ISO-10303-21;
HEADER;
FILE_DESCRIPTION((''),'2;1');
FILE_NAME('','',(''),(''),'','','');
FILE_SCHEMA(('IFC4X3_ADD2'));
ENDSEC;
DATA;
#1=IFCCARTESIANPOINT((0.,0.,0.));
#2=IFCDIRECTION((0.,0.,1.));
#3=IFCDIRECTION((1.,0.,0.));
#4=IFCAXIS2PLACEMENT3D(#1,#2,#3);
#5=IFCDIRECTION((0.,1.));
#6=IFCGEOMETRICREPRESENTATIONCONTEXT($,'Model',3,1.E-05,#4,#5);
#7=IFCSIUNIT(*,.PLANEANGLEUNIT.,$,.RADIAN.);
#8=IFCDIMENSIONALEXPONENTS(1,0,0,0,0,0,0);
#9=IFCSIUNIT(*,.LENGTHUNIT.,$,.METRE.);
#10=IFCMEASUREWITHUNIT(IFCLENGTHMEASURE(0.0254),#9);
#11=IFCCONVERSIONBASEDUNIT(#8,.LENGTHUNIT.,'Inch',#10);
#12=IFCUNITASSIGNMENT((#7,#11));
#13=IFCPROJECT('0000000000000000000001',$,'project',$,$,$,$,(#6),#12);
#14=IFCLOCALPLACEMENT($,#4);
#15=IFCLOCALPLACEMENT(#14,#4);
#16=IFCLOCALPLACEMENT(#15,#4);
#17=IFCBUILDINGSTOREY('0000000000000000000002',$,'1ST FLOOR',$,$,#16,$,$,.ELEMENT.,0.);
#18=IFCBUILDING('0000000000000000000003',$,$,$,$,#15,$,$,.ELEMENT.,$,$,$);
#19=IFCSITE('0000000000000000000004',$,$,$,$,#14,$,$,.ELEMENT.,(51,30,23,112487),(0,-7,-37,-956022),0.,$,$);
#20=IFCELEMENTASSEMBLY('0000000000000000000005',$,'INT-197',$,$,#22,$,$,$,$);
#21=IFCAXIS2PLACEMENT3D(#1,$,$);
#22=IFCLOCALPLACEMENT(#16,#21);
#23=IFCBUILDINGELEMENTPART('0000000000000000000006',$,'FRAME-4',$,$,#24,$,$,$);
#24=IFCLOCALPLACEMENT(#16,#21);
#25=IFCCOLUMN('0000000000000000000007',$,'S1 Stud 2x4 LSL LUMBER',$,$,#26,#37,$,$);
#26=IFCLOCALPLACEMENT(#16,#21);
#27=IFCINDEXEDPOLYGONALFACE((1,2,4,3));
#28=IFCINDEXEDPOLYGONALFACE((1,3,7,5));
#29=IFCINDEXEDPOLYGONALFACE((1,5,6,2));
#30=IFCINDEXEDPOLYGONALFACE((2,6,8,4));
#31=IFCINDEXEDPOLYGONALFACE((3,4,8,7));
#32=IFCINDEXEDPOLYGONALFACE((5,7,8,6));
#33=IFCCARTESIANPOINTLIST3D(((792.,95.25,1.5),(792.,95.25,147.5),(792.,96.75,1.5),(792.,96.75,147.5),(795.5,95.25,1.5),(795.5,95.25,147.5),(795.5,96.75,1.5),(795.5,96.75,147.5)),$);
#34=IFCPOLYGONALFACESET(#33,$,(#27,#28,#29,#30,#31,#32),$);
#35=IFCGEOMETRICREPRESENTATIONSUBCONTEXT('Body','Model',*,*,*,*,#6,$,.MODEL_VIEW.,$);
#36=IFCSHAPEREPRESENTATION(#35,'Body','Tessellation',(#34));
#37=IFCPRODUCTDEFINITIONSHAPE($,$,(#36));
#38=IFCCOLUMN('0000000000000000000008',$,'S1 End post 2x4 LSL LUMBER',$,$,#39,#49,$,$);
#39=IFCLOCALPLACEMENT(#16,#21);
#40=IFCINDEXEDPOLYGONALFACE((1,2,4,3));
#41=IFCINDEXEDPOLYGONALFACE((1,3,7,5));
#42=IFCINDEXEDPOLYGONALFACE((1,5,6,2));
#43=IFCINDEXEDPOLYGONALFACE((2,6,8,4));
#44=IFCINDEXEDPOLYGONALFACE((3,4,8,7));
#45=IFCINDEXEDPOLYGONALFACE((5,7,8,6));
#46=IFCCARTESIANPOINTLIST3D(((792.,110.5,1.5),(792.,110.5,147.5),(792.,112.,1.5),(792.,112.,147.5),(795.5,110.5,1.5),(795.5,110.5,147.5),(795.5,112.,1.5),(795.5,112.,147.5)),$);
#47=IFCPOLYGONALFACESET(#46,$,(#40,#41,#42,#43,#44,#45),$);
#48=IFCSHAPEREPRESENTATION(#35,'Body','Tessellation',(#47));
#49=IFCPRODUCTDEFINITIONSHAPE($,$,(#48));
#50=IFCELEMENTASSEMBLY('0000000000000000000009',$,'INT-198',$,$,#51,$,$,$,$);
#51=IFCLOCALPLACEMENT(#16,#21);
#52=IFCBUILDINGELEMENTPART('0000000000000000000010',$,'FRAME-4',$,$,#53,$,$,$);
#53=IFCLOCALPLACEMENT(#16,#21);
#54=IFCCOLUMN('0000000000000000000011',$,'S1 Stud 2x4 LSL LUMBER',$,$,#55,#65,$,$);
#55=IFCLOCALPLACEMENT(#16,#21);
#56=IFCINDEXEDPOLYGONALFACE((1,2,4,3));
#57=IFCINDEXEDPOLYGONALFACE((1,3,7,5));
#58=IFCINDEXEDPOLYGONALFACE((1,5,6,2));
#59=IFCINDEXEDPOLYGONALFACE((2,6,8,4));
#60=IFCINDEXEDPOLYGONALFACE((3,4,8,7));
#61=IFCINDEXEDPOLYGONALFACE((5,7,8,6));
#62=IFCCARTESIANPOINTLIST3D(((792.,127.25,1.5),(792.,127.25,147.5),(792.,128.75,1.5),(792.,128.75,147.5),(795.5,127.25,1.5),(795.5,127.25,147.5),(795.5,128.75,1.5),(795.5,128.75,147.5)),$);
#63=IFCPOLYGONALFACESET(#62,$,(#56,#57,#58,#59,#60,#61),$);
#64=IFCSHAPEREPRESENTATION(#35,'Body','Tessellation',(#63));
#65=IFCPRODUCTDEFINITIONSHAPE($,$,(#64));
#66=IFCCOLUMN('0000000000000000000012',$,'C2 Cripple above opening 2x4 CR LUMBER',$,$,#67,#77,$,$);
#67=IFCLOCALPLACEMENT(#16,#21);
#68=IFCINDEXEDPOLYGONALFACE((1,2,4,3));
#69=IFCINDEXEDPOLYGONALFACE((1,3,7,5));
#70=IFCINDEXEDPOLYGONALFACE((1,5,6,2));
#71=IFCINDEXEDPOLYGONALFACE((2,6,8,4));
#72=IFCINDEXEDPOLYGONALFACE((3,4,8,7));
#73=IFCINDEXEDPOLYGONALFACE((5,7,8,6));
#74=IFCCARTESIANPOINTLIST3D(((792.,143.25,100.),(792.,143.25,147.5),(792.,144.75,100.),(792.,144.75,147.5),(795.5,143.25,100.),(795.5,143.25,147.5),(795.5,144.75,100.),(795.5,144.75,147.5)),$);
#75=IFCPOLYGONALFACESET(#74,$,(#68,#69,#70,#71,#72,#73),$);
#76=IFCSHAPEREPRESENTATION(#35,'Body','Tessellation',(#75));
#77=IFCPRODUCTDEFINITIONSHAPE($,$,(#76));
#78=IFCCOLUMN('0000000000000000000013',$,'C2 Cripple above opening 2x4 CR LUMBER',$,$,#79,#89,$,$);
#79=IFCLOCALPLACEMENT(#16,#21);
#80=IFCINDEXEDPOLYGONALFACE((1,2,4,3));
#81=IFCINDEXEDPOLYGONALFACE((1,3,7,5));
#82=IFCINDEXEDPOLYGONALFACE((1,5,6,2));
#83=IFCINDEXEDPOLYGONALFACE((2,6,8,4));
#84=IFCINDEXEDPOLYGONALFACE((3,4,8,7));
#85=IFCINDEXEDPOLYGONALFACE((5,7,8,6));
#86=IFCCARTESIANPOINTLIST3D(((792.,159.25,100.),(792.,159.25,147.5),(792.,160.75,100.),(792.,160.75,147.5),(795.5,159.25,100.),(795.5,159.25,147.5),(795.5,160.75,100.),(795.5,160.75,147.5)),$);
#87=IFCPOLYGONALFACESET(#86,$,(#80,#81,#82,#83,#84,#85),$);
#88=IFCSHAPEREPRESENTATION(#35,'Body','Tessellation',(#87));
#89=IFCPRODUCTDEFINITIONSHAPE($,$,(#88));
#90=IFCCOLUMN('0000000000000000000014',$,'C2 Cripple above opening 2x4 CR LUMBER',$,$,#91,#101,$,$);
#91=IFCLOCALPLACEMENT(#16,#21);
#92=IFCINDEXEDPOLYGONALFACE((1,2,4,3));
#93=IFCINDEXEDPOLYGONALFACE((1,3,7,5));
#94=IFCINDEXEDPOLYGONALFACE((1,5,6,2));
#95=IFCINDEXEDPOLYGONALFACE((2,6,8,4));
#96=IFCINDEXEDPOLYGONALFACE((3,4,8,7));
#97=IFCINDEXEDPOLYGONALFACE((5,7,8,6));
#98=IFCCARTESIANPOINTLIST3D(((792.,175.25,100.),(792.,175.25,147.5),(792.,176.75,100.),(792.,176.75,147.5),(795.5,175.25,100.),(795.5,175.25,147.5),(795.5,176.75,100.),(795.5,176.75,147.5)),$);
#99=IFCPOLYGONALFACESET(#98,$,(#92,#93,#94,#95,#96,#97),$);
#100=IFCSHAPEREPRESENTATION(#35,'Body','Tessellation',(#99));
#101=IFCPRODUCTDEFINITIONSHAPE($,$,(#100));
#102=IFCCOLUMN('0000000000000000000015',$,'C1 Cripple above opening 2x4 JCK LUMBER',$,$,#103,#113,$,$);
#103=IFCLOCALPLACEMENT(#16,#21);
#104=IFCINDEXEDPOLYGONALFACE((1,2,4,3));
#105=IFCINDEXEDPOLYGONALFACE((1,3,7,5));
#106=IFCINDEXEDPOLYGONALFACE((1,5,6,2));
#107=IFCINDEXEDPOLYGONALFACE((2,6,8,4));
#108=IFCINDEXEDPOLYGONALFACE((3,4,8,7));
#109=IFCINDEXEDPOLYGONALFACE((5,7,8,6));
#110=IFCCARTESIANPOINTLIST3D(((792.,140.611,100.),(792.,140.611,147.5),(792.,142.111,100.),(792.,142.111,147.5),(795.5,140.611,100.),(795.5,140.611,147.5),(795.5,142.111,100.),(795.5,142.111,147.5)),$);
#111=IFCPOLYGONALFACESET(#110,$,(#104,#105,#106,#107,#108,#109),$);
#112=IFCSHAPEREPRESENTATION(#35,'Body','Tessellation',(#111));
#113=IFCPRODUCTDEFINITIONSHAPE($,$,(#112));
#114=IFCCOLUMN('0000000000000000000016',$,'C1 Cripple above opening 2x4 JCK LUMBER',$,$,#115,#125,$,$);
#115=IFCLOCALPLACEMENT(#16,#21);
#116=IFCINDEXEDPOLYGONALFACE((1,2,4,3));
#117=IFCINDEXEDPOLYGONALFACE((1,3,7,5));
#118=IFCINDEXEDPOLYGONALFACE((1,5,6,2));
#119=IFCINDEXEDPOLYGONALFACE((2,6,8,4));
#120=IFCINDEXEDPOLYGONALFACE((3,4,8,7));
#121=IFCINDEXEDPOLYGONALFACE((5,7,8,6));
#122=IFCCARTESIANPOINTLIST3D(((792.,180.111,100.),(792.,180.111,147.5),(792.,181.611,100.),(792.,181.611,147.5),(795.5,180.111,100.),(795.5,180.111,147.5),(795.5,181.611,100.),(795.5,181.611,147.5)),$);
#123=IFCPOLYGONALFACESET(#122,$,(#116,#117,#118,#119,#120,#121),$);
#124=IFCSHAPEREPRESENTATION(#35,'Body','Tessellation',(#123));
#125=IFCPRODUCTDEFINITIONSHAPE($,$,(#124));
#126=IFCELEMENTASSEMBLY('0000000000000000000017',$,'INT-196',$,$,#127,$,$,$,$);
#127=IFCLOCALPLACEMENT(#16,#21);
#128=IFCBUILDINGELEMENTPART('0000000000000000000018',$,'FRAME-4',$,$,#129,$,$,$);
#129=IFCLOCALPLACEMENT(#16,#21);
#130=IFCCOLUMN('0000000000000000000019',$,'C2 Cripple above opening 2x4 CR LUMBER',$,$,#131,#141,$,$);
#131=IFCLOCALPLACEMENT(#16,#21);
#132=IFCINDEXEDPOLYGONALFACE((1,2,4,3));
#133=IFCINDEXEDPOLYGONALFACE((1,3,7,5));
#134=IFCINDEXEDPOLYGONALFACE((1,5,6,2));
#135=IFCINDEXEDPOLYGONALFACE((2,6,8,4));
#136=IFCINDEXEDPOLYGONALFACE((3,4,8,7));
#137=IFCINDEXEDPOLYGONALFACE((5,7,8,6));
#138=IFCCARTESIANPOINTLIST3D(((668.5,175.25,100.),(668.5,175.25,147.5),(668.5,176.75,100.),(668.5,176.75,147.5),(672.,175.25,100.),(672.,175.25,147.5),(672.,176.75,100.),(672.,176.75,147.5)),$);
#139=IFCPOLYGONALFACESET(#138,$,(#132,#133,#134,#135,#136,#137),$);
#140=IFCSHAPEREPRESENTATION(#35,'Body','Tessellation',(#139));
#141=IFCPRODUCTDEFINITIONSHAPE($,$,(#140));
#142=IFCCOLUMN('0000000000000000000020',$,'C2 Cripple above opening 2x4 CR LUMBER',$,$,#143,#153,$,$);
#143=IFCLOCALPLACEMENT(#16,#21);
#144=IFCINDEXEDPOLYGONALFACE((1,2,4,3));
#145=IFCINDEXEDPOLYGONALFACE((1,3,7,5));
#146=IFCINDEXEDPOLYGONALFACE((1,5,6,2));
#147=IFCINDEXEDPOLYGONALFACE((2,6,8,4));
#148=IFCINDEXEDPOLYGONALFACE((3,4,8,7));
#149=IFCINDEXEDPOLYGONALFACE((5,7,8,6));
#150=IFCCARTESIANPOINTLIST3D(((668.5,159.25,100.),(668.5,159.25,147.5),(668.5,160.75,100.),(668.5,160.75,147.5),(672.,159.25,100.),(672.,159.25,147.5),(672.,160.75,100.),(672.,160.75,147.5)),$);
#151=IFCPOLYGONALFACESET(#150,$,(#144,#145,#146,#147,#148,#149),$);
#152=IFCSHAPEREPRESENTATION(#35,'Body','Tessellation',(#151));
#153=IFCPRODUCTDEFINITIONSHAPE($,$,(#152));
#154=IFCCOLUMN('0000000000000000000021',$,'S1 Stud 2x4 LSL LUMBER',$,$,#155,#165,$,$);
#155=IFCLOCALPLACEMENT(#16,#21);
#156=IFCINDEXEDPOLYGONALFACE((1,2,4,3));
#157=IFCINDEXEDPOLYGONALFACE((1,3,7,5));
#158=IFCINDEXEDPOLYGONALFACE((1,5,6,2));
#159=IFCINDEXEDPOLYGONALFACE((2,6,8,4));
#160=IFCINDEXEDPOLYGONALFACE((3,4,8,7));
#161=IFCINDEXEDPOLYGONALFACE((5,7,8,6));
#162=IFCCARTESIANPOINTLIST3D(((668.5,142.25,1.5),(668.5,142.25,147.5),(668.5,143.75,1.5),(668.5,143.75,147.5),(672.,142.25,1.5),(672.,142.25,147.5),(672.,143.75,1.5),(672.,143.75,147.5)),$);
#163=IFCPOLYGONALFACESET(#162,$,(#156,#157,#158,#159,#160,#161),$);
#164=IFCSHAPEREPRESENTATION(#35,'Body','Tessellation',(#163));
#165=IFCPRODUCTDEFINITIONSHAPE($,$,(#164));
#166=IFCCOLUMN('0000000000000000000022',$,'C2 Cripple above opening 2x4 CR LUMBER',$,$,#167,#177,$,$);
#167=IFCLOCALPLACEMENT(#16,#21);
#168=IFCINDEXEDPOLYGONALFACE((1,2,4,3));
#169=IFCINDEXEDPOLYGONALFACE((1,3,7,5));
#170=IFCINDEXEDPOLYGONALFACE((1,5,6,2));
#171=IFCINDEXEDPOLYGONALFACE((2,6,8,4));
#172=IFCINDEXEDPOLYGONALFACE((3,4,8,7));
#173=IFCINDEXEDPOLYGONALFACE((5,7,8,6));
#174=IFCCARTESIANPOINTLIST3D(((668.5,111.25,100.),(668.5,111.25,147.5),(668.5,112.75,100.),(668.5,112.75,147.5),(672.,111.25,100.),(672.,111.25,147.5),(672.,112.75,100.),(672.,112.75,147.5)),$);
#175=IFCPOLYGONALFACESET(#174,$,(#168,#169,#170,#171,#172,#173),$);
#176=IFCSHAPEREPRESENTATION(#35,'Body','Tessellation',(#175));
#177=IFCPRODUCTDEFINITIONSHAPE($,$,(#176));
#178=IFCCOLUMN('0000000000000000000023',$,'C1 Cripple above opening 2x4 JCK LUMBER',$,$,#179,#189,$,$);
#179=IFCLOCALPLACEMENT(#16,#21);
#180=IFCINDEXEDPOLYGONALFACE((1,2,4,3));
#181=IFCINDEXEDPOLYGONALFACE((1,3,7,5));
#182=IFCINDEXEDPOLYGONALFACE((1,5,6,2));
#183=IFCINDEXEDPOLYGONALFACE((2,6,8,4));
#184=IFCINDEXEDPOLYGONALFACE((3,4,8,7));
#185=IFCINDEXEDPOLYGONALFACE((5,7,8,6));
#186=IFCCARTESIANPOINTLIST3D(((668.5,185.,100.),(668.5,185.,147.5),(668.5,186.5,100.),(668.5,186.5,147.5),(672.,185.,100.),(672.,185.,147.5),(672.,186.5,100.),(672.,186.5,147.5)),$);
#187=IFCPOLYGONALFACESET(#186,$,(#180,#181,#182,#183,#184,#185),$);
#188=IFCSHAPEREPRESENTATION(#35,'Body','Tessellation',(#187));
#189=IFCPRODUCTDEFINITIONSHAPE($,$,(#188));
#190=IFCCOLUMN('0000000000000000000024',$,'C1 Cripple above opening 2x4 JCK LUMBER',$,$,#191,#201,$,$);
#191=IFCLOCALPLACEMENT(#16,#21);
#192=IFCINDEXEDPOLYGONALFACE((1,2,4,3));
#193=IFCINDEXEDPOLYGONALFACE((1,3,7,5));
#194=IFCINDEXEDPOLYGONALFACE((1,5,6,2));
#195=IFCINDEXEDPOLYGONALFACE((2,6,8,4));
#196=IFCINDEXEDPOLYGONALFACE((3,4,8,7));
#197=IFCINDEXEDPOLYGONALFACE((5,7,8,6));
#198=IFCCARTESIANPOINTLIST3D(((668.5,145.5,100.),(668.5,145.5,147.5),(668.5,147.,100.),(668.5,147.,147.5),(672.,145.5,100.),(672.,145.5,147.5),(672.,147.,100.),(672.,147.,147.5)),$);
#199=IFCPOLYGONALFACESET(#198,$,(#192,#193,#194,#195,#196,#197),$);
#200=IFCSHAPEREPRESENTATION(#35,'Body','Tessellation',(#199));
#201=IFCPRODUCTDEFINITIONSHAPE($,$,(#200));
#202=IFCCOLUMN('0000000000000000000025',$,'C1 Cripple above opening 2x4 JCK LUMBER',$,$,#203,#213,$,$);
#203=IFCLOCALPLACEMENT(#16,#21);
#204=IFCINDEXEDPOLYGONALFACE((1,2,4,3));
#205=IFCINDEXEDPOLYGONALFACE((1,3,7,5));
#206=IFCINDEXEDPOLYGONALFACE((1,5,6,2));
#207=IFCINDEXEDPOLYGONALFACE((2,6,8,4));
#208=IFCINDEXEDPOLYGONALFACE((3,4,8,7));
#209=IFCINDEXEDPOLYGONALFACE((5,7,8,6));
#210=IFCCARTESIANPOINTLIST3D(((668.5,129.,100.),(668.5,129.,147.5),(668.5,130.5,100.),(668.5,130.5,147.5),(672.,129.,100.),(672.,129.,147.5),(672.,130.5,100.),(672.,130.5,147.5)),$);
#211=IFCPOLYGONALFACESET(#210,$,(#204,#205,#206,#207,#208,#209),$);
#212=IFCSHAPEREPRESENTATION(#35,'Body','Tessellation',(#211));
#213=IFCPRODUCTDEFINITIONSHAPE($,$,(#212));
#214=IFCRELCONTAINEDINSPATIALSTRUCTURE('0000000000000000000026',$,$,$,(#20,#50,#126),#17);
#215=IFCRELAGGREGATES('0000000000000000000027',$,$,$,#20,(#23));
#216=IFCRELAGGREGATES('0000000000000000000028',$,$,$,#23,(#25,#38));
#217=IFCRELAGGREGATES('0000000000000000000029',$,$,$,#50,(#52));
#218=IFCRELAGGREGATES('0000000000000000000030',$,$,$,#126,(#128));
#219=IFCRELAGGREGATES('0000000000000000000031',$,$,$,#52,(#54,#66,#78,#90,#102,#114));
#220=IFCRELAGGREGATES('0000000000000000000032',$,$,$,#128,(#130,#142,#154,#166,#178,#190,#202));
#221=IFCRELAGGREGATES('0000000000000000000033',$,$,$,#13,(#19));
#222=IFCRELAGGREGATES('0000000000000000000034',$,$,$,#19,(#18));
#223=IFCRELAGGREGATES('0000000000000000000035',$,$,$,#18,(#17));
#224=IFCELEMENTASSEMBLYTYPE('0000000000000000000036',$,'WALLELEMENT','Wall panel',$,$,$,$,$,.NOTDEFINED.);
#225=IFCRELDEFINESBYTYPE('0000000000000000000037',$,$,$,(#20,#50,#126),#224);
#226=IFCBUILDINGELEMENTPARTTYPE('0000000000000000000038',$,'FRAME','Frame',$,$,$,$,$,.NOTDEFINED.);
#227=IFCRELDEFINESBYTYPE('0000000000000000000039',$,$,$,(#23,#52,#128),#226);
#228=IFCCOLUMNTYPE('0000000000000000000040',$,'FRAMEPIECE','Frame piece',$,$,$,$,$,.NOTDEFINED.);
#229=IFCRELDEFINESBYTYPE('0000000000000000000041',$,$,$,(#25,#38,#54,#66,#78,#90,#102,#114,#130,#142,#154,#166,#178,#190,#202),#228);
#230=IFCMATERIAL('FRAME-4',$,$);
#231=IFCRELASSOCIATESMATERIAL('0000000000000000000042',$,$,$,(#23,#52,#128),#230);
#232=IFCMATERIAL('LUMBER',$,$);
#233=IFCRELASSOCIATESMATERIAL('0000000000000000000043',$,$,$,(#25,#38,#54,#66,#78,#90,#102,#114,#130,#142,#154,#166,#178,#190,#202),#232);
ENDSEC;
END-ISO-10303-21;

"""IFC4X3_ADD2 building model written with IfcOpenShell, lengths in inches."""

from ifc_helpers import new_model, entity, si_unit, converted_unit, direction, frame, origin_with_axes, origin_2d_with_axis, place, context, subcontext, project, spatial, rectangle, extrude, material, type_object, element, aggregate, save


model = new_model("IFC4X3_ADD2")

# Units and contexts
model_context = context("Model", 3, precision=1e-05, world=origin_with_axes(), true_north=direction((0.0, 1.0)))
body_context = subcontext(model_context, "Body", "Model", "MODEL_VIEW")
ifc_project = project(units=[si_unit("PLANEANGLEUNIT", "RADIAN"), converted_unit("LENGTHUNIT", "Inch", entity("IfcLengthMeasure", 0.0254), si_unit("LENGTHUNIT", "METRE"), dimensions=[1, 0, 0, 0, 0, 0, 0])], contexts=[model_context])

# Site, building, storey
site_placement = place(None, origin_with_axes())
site = spatial("IfcSite", under=ifc_project, at=site_placement, CompositionType="ELEMENT", RefLatitude=(51, 30, 23, 112487), RefLongitude=(0, -7, -37, -956022), RefElevation=0.0)
building_placement = place(site_placement, origin_with_axes())
building = spatial("IfcBuilding", under=site, at=building_placement, CompositionType="ELEMENT")
storey_placement = place(building_placement, origin_with_axes())
storey = spatial("IfcBuildingStorey", under=building, at=storey_placement, Name="1ST FLOOR", CompositionType="ELEMENT", Elevation=0.0)

# Element assemblies, building element parts, columns
element_assembly_type = type_object("IfcElementAssemblyType", Name="WALLELEMENT", Description="Wall panel", PredefinedType="NOTDEFINED")
assembly_1_placement = place(storey_placement, origin_with_axes())
assembly_1 = element("IfcElementAssembly", 1, at=assembly_1_placement, inside=storey, type_object=element_assembly_type, Name="INT-197")
ifc_material_1 = material(Name="FRAME-4")
building_element_part_type = type_object("IfcBuildingElementPartType", Name="FRAME", Description="Frame", PredefinedType="NOTDEFINED")
building_element_part_1_placement = place(storey_placement, origin_with_axes())
building_element_part_1 = element("IfcBuildingElementPart", 2, at=building_element_part_1_placement, type_object=building_element_part_type, material=ifc_material_1, Name="FRAME-4")
aggregate(assembly_1, [building_element_part_1])
ifc_material_2 = material(Name="LUMBER")
column_type = type_object("IfcColumnType", Name="FRAMEPIECE", Description="Frame piece", PredefinedType="NOTDEFINED")
column_1_placement = place(storey_placement, frame((793.75, 96.0, 147.5), z_axis=(0.0, 0.0, -1.0), x_axis=(0.0, -1.0, 0.0)))
column_1 = element("IfcColumn", 3, at=column_1_placement, type_object=column_type, material=ifc_material_2, Name="S1 Stud 2x4 LSL LUMBER", context=body_context, shape_type="SweptSolid", body=[
    extrude(rectangle(XDim=1.5, YDim=3.5, at=origin_2d_with_axis()), origin_with_axes(), (0.0, 0.0, 1.0), 146.0),
])
column_2_placement = place(storey_placement, frame((793.75, 111.25, 147.5), z_axis=(0.0, 0.0, -1.0), x_axis=(0.0, -1.0, 0.0)))
column_2 = element("IfcColumn", 4, at=column_2_placement, type_object=column_type, material=ifc_material_2, Name="S1 End post 2x4 LSL LUMBER", context=body_context, shape_type="SweptSolid", body=[
    extrude(rectangle(XDim=1.5, YDim=3.5, at=origin_2d_with_axis()), origin_with_axes(), (0.0, 0.0, 1.0), 146.0),
])
aggregate(building_element_part_1, [column_1, column_2])
assembly_2_placement = place(storey_placement, origin_with_axes())
assembly_2 = element("IfcElementAssembly", 5, at=assembly_2_placement, inside=storey, type_object=element_assembly_type, Name="INT-198")
building_element_part_2_placement = place(storey_placement, origin_with_axes())
building_element_part_2 = element("IfcBuildingElementPart", 6, at=building_element_part_2_placement, type_object=building_element_part_type, material=ifc_material_1, Name="FRAME-4")
aggregate(assembly_2, [building_element_part_2])
column_3_placement = place(storey_placement, frame((793.75, 128.0, 147.5), z_axis=(0.0, 0.0, -1.0), x_axis=(0.0, -1.0, 0.0)))
column_3 = element("IfcColumn", 7, at=column_3_placement, type_object=column_type, material=ifc_material_2, Name="S1 Stud 2x4 LSL LUMBER", context=body_context, shape_type="SweptSolid", body=[
    extrude(rectangle(XDim=1.5, YDim=3.5, at=origin_2d_with_axis()), origin_with_axes(), (0.0, 0.0, 1.0), 146.0),
])
column_4_placement = place(storey_placement, frame((793.75, 144.0, 147.5), z_axis=(0.0, 0.0, -1.0), x_axis=(0.0, -1.0, 0.0)))
column_4 = element("IfcColumn", 8, at=column_4_placement, type_object=column_type, material=ifc_material_2, Name="C2 Cripple above opening 2x4 CR LUMBER", context=body_context, shape_type="SweptSolid", body=[
    extrude(rectangle(XDim=1.5, YDim=3.5, at=origin_2d_with_axis()), origin_with_axes(), (0.0, 0.0, 1.0), 47.5),
])
column_5_placement = place(storey_placement, frame((793.75, 160.0, 147.5), z_axis=(0.0, 0.0, -1.0), x_axis=(0.0, -1.0, 0.0)))
column_5 = element("IfcColumn", 9, at=column_5_placement, type_object=column_type, material=ifc_material_2, Name="C2 Cripple above opening 2x4 CR LUMBER", context=body_context, shape_type="SweptSolid", body=[
    extrude(rectangle(XDim=1.5, YDim=3.5, at=origin_2d_with_axis()), origin_with_axes(), (0.0, 0.0, 1.0), 47.5),
])
column_6_placement = place(storey_placement, frame((793.75, 176.0, 147.5), z_axis=(0.0, 0.0, -1.0), x_axis=(0.0, -1.0, 0.0)))
column_6 = element("IfcColumn", 10, at=column_6_placement, type_object=column_type, material=ifc_material_2, Name="C2 Cripple above opening 2x4 CR LUMBER", context=body_context, shape_type="SweptSolid", body=[
    extrude(rectangle(XDim=1.5, YDim=3.5, at=origin_2d_with_axis()), origin_with_axes(), (0.0, 0.0, 1.0), 47.5),
])
column_7_placement = place(storey_placement, frame((793.75, 141.361, 100.0), z_axis=(0.0, 0.0, 1.0), x_axis=(0.0, 1.0, 0.0)))
column_7 = element("IfcColumn", 11, at=column_7_placement, type_object=column_type, material=ifc_material_2, Name="C1 Cripple above opening 2x4 JCK LUMBER", context=body_context, shape_type="SweptSolid", body=[
    extrude(rectangle(XDim=1.5, YDim=3.5, at=origin_2d_with_axis()), origin_with_axes(), (0.0, 0.0, 1.0), 47.5),
])
column_8_placement = place(storey_placement, frame((793.75, 180.861, 147.5), z_axis=(0.0, 0.0, -1.0), x_axis=(0.0, -1.0, 0.0)))
column_8 = element("IfcColumn", 12, at=column_8_placement, type_object=column_type, material=ifc_material_2, Name="C1 Cripple above opening 2x4 JCK LUMBER", context=body_context, shape_type="SweptSolid", body=[
    extrude(rectangle(XDim=1.5, YDim=3.5, at=origin_2d_with_axis()), origin_with_axes(), (0.0, 0.0, 1.0), 47.5),
])
assembly_3_placement = place(storey_placement, origin_with_axes())
assembly_3 = element("IfcElementAssembly", 13, at=assembly_3_placement, inside=storey, type_object=element_assembly_type, Name="INT-196")
building_element_part_3_placement = place(storey_placement, origin_with_axes())
building_element_part_3 = element("IfcBuildingElementPart", 14, at=building_element_part_3_placement, type_object=building_element_part_type, material=ifc_material_1, Name="FRAME-4")
aggregate(assembly_3, [building_element_part_3])
column_9_placement = place(storey_placement, frame((670.25, 176.0, 147.5), z_axis=(0.0, 0.0, -1.0), x_axis=(0.0, 1.0, 0.0)))
column_9 = element("IfcColumn", 15, at=column_9_placement, type_object=column_type, material=ifc_material_2, Name="C2 Cripple above opening 2x4 CR LUMBER", context=body_context, shape_type="SweptSolid", body=[
    extrude(rectangle(XDim=1.5, YDim=3.5, at=origin_2d_with_axis()), origin_with_axes(), (0.0, 0.0, 1.0), 47.5),
])
column_10_placement = place(storey_placement, frame((670.25, 160.0, 147.5), z_axis=(0.0, 0.0, -1.0), x_axis=(0.0, 1.0, 0.0)))
column_10 = element("IfcColumn", 16, at=column_10_placement, type_object=column_type, material=ifc_material_2, Name="C2 Cripple above opening 2x4 CR LUMBER", context=body_context, shape_type="SweptSolid", body=[
    extrude(rectangle(XDim=1.5, YDim=3.5, at=origin_2d_with_axis()), origin_with_axes(), (0.0, 0.0, 1.0), 47.5),
])
column_11_placement = place(storey_placement, frame((670.25, 143.0, 147.5), z_axis=(0.0, 0.0, -1.0), x_axis=(0.0, 1.0, 0.0)))
column_11 = element("IfcColumn", 17, at=column_11_placement, type_object=column_type, material=ifc_material_2, Name="S1 Stud 2x4 LSL LUMBER", context=body_context, shape_type="SweptSolid", body=[
    extrude(rectangle(XDim=1.5, YDim=3.5, at=origin_2d_with_axis()), origin_with_axes(), (0.0, 0.0, 1.0), 146.0),
])
column_12_placement = place(storey_placement, frame((670.25, 112.0, 147.5), z_axis=(0.0, 0.0, -1.0), x_axis=(0.0, 1.0, 0.0)))
column_12 = element("IfcColumn", 18, at=column_12_placement, type_object=column_type, material=ifc_material_2, Name="C2 Cripple above opening 2x4 CR LUMBER", context=body_context, shape_type="SweptSolid", body=[
    extrude(rectangle(XDim=1.5, YDim=3.5, at=origin_2d_with_axis()), origin_with_axes(), (0.0, 0.0, 1.0), 47.5),
])
column_13_placement = place(storey_placement, frame((670.25, 185.75, 100.0), z_axis=(0.0, 0.0, 1.0), x_axis=(0.0, -1.0, 0.0)))
column_13 = element("IfcColumn", 19, at=column_13_placement, type_object=column_type, material=ifc_material_2, Name="C1 Cripple above opening 2x4 JCK LUMBER", context=body_context, shape_type="SweptSolid", body=[
    extrude(rectangle(XDim=1.5, YDim=3.5, at=origin_2d_with_axis()), origin_with_axes(), (0.0, 0.0, 1.0), 47.5),
])
column_14_placement = place(storey_placement, frame((670.25, 146.25, 147.5), z_axis=(0.0, 0.0, -1.0), x_axis=(0.0, 1.0, 0.0)))
column_14 = element("IfcColumn", 20, at=column_14_placement, type_object=column_type, material=ifc_material_2, Name="C1 Cripple above opening 2x4 JCK LUMBER", context=body_context, shape_type="SweptSolid", body=[
    extrude(rectangle(XDim=1.5, YDim=3.5, at=origin_2d_with_axis()), origin_with_axes(), (0.0, 0.0, 1.0), 47.5),
])
column_15_placement = place(storey_placement, frame((670.25, 129.75, 100.0), z_axis=(0.0, 0.0, 1.0), x_axis=(0.0, -1.0, 0.0)))
column_15 = element("IfcColumn", 21, at=column_15_placement, type_object=column_type, material=ifc_material_2, Name="C1 Cripple above opening 2x4 JCK LUMBER", context=body_context, shape_type="SweptSolid", body=[
    extrude(rectangle(XDim=1.5, YDim=3.5, at=origin_2d_with_axis()), origin_with_axes(), (0.0, 0.0, 1.0), 47.5),
])

aggregate(building_element_part_2, [column_3, column_4, column_5, column_6, column_7, column_8])
aggregate(building_element_part_3, [column_9, column_10, column_11, column_12, column_13, column_14, column_15])

save(model, "model.ifc")
